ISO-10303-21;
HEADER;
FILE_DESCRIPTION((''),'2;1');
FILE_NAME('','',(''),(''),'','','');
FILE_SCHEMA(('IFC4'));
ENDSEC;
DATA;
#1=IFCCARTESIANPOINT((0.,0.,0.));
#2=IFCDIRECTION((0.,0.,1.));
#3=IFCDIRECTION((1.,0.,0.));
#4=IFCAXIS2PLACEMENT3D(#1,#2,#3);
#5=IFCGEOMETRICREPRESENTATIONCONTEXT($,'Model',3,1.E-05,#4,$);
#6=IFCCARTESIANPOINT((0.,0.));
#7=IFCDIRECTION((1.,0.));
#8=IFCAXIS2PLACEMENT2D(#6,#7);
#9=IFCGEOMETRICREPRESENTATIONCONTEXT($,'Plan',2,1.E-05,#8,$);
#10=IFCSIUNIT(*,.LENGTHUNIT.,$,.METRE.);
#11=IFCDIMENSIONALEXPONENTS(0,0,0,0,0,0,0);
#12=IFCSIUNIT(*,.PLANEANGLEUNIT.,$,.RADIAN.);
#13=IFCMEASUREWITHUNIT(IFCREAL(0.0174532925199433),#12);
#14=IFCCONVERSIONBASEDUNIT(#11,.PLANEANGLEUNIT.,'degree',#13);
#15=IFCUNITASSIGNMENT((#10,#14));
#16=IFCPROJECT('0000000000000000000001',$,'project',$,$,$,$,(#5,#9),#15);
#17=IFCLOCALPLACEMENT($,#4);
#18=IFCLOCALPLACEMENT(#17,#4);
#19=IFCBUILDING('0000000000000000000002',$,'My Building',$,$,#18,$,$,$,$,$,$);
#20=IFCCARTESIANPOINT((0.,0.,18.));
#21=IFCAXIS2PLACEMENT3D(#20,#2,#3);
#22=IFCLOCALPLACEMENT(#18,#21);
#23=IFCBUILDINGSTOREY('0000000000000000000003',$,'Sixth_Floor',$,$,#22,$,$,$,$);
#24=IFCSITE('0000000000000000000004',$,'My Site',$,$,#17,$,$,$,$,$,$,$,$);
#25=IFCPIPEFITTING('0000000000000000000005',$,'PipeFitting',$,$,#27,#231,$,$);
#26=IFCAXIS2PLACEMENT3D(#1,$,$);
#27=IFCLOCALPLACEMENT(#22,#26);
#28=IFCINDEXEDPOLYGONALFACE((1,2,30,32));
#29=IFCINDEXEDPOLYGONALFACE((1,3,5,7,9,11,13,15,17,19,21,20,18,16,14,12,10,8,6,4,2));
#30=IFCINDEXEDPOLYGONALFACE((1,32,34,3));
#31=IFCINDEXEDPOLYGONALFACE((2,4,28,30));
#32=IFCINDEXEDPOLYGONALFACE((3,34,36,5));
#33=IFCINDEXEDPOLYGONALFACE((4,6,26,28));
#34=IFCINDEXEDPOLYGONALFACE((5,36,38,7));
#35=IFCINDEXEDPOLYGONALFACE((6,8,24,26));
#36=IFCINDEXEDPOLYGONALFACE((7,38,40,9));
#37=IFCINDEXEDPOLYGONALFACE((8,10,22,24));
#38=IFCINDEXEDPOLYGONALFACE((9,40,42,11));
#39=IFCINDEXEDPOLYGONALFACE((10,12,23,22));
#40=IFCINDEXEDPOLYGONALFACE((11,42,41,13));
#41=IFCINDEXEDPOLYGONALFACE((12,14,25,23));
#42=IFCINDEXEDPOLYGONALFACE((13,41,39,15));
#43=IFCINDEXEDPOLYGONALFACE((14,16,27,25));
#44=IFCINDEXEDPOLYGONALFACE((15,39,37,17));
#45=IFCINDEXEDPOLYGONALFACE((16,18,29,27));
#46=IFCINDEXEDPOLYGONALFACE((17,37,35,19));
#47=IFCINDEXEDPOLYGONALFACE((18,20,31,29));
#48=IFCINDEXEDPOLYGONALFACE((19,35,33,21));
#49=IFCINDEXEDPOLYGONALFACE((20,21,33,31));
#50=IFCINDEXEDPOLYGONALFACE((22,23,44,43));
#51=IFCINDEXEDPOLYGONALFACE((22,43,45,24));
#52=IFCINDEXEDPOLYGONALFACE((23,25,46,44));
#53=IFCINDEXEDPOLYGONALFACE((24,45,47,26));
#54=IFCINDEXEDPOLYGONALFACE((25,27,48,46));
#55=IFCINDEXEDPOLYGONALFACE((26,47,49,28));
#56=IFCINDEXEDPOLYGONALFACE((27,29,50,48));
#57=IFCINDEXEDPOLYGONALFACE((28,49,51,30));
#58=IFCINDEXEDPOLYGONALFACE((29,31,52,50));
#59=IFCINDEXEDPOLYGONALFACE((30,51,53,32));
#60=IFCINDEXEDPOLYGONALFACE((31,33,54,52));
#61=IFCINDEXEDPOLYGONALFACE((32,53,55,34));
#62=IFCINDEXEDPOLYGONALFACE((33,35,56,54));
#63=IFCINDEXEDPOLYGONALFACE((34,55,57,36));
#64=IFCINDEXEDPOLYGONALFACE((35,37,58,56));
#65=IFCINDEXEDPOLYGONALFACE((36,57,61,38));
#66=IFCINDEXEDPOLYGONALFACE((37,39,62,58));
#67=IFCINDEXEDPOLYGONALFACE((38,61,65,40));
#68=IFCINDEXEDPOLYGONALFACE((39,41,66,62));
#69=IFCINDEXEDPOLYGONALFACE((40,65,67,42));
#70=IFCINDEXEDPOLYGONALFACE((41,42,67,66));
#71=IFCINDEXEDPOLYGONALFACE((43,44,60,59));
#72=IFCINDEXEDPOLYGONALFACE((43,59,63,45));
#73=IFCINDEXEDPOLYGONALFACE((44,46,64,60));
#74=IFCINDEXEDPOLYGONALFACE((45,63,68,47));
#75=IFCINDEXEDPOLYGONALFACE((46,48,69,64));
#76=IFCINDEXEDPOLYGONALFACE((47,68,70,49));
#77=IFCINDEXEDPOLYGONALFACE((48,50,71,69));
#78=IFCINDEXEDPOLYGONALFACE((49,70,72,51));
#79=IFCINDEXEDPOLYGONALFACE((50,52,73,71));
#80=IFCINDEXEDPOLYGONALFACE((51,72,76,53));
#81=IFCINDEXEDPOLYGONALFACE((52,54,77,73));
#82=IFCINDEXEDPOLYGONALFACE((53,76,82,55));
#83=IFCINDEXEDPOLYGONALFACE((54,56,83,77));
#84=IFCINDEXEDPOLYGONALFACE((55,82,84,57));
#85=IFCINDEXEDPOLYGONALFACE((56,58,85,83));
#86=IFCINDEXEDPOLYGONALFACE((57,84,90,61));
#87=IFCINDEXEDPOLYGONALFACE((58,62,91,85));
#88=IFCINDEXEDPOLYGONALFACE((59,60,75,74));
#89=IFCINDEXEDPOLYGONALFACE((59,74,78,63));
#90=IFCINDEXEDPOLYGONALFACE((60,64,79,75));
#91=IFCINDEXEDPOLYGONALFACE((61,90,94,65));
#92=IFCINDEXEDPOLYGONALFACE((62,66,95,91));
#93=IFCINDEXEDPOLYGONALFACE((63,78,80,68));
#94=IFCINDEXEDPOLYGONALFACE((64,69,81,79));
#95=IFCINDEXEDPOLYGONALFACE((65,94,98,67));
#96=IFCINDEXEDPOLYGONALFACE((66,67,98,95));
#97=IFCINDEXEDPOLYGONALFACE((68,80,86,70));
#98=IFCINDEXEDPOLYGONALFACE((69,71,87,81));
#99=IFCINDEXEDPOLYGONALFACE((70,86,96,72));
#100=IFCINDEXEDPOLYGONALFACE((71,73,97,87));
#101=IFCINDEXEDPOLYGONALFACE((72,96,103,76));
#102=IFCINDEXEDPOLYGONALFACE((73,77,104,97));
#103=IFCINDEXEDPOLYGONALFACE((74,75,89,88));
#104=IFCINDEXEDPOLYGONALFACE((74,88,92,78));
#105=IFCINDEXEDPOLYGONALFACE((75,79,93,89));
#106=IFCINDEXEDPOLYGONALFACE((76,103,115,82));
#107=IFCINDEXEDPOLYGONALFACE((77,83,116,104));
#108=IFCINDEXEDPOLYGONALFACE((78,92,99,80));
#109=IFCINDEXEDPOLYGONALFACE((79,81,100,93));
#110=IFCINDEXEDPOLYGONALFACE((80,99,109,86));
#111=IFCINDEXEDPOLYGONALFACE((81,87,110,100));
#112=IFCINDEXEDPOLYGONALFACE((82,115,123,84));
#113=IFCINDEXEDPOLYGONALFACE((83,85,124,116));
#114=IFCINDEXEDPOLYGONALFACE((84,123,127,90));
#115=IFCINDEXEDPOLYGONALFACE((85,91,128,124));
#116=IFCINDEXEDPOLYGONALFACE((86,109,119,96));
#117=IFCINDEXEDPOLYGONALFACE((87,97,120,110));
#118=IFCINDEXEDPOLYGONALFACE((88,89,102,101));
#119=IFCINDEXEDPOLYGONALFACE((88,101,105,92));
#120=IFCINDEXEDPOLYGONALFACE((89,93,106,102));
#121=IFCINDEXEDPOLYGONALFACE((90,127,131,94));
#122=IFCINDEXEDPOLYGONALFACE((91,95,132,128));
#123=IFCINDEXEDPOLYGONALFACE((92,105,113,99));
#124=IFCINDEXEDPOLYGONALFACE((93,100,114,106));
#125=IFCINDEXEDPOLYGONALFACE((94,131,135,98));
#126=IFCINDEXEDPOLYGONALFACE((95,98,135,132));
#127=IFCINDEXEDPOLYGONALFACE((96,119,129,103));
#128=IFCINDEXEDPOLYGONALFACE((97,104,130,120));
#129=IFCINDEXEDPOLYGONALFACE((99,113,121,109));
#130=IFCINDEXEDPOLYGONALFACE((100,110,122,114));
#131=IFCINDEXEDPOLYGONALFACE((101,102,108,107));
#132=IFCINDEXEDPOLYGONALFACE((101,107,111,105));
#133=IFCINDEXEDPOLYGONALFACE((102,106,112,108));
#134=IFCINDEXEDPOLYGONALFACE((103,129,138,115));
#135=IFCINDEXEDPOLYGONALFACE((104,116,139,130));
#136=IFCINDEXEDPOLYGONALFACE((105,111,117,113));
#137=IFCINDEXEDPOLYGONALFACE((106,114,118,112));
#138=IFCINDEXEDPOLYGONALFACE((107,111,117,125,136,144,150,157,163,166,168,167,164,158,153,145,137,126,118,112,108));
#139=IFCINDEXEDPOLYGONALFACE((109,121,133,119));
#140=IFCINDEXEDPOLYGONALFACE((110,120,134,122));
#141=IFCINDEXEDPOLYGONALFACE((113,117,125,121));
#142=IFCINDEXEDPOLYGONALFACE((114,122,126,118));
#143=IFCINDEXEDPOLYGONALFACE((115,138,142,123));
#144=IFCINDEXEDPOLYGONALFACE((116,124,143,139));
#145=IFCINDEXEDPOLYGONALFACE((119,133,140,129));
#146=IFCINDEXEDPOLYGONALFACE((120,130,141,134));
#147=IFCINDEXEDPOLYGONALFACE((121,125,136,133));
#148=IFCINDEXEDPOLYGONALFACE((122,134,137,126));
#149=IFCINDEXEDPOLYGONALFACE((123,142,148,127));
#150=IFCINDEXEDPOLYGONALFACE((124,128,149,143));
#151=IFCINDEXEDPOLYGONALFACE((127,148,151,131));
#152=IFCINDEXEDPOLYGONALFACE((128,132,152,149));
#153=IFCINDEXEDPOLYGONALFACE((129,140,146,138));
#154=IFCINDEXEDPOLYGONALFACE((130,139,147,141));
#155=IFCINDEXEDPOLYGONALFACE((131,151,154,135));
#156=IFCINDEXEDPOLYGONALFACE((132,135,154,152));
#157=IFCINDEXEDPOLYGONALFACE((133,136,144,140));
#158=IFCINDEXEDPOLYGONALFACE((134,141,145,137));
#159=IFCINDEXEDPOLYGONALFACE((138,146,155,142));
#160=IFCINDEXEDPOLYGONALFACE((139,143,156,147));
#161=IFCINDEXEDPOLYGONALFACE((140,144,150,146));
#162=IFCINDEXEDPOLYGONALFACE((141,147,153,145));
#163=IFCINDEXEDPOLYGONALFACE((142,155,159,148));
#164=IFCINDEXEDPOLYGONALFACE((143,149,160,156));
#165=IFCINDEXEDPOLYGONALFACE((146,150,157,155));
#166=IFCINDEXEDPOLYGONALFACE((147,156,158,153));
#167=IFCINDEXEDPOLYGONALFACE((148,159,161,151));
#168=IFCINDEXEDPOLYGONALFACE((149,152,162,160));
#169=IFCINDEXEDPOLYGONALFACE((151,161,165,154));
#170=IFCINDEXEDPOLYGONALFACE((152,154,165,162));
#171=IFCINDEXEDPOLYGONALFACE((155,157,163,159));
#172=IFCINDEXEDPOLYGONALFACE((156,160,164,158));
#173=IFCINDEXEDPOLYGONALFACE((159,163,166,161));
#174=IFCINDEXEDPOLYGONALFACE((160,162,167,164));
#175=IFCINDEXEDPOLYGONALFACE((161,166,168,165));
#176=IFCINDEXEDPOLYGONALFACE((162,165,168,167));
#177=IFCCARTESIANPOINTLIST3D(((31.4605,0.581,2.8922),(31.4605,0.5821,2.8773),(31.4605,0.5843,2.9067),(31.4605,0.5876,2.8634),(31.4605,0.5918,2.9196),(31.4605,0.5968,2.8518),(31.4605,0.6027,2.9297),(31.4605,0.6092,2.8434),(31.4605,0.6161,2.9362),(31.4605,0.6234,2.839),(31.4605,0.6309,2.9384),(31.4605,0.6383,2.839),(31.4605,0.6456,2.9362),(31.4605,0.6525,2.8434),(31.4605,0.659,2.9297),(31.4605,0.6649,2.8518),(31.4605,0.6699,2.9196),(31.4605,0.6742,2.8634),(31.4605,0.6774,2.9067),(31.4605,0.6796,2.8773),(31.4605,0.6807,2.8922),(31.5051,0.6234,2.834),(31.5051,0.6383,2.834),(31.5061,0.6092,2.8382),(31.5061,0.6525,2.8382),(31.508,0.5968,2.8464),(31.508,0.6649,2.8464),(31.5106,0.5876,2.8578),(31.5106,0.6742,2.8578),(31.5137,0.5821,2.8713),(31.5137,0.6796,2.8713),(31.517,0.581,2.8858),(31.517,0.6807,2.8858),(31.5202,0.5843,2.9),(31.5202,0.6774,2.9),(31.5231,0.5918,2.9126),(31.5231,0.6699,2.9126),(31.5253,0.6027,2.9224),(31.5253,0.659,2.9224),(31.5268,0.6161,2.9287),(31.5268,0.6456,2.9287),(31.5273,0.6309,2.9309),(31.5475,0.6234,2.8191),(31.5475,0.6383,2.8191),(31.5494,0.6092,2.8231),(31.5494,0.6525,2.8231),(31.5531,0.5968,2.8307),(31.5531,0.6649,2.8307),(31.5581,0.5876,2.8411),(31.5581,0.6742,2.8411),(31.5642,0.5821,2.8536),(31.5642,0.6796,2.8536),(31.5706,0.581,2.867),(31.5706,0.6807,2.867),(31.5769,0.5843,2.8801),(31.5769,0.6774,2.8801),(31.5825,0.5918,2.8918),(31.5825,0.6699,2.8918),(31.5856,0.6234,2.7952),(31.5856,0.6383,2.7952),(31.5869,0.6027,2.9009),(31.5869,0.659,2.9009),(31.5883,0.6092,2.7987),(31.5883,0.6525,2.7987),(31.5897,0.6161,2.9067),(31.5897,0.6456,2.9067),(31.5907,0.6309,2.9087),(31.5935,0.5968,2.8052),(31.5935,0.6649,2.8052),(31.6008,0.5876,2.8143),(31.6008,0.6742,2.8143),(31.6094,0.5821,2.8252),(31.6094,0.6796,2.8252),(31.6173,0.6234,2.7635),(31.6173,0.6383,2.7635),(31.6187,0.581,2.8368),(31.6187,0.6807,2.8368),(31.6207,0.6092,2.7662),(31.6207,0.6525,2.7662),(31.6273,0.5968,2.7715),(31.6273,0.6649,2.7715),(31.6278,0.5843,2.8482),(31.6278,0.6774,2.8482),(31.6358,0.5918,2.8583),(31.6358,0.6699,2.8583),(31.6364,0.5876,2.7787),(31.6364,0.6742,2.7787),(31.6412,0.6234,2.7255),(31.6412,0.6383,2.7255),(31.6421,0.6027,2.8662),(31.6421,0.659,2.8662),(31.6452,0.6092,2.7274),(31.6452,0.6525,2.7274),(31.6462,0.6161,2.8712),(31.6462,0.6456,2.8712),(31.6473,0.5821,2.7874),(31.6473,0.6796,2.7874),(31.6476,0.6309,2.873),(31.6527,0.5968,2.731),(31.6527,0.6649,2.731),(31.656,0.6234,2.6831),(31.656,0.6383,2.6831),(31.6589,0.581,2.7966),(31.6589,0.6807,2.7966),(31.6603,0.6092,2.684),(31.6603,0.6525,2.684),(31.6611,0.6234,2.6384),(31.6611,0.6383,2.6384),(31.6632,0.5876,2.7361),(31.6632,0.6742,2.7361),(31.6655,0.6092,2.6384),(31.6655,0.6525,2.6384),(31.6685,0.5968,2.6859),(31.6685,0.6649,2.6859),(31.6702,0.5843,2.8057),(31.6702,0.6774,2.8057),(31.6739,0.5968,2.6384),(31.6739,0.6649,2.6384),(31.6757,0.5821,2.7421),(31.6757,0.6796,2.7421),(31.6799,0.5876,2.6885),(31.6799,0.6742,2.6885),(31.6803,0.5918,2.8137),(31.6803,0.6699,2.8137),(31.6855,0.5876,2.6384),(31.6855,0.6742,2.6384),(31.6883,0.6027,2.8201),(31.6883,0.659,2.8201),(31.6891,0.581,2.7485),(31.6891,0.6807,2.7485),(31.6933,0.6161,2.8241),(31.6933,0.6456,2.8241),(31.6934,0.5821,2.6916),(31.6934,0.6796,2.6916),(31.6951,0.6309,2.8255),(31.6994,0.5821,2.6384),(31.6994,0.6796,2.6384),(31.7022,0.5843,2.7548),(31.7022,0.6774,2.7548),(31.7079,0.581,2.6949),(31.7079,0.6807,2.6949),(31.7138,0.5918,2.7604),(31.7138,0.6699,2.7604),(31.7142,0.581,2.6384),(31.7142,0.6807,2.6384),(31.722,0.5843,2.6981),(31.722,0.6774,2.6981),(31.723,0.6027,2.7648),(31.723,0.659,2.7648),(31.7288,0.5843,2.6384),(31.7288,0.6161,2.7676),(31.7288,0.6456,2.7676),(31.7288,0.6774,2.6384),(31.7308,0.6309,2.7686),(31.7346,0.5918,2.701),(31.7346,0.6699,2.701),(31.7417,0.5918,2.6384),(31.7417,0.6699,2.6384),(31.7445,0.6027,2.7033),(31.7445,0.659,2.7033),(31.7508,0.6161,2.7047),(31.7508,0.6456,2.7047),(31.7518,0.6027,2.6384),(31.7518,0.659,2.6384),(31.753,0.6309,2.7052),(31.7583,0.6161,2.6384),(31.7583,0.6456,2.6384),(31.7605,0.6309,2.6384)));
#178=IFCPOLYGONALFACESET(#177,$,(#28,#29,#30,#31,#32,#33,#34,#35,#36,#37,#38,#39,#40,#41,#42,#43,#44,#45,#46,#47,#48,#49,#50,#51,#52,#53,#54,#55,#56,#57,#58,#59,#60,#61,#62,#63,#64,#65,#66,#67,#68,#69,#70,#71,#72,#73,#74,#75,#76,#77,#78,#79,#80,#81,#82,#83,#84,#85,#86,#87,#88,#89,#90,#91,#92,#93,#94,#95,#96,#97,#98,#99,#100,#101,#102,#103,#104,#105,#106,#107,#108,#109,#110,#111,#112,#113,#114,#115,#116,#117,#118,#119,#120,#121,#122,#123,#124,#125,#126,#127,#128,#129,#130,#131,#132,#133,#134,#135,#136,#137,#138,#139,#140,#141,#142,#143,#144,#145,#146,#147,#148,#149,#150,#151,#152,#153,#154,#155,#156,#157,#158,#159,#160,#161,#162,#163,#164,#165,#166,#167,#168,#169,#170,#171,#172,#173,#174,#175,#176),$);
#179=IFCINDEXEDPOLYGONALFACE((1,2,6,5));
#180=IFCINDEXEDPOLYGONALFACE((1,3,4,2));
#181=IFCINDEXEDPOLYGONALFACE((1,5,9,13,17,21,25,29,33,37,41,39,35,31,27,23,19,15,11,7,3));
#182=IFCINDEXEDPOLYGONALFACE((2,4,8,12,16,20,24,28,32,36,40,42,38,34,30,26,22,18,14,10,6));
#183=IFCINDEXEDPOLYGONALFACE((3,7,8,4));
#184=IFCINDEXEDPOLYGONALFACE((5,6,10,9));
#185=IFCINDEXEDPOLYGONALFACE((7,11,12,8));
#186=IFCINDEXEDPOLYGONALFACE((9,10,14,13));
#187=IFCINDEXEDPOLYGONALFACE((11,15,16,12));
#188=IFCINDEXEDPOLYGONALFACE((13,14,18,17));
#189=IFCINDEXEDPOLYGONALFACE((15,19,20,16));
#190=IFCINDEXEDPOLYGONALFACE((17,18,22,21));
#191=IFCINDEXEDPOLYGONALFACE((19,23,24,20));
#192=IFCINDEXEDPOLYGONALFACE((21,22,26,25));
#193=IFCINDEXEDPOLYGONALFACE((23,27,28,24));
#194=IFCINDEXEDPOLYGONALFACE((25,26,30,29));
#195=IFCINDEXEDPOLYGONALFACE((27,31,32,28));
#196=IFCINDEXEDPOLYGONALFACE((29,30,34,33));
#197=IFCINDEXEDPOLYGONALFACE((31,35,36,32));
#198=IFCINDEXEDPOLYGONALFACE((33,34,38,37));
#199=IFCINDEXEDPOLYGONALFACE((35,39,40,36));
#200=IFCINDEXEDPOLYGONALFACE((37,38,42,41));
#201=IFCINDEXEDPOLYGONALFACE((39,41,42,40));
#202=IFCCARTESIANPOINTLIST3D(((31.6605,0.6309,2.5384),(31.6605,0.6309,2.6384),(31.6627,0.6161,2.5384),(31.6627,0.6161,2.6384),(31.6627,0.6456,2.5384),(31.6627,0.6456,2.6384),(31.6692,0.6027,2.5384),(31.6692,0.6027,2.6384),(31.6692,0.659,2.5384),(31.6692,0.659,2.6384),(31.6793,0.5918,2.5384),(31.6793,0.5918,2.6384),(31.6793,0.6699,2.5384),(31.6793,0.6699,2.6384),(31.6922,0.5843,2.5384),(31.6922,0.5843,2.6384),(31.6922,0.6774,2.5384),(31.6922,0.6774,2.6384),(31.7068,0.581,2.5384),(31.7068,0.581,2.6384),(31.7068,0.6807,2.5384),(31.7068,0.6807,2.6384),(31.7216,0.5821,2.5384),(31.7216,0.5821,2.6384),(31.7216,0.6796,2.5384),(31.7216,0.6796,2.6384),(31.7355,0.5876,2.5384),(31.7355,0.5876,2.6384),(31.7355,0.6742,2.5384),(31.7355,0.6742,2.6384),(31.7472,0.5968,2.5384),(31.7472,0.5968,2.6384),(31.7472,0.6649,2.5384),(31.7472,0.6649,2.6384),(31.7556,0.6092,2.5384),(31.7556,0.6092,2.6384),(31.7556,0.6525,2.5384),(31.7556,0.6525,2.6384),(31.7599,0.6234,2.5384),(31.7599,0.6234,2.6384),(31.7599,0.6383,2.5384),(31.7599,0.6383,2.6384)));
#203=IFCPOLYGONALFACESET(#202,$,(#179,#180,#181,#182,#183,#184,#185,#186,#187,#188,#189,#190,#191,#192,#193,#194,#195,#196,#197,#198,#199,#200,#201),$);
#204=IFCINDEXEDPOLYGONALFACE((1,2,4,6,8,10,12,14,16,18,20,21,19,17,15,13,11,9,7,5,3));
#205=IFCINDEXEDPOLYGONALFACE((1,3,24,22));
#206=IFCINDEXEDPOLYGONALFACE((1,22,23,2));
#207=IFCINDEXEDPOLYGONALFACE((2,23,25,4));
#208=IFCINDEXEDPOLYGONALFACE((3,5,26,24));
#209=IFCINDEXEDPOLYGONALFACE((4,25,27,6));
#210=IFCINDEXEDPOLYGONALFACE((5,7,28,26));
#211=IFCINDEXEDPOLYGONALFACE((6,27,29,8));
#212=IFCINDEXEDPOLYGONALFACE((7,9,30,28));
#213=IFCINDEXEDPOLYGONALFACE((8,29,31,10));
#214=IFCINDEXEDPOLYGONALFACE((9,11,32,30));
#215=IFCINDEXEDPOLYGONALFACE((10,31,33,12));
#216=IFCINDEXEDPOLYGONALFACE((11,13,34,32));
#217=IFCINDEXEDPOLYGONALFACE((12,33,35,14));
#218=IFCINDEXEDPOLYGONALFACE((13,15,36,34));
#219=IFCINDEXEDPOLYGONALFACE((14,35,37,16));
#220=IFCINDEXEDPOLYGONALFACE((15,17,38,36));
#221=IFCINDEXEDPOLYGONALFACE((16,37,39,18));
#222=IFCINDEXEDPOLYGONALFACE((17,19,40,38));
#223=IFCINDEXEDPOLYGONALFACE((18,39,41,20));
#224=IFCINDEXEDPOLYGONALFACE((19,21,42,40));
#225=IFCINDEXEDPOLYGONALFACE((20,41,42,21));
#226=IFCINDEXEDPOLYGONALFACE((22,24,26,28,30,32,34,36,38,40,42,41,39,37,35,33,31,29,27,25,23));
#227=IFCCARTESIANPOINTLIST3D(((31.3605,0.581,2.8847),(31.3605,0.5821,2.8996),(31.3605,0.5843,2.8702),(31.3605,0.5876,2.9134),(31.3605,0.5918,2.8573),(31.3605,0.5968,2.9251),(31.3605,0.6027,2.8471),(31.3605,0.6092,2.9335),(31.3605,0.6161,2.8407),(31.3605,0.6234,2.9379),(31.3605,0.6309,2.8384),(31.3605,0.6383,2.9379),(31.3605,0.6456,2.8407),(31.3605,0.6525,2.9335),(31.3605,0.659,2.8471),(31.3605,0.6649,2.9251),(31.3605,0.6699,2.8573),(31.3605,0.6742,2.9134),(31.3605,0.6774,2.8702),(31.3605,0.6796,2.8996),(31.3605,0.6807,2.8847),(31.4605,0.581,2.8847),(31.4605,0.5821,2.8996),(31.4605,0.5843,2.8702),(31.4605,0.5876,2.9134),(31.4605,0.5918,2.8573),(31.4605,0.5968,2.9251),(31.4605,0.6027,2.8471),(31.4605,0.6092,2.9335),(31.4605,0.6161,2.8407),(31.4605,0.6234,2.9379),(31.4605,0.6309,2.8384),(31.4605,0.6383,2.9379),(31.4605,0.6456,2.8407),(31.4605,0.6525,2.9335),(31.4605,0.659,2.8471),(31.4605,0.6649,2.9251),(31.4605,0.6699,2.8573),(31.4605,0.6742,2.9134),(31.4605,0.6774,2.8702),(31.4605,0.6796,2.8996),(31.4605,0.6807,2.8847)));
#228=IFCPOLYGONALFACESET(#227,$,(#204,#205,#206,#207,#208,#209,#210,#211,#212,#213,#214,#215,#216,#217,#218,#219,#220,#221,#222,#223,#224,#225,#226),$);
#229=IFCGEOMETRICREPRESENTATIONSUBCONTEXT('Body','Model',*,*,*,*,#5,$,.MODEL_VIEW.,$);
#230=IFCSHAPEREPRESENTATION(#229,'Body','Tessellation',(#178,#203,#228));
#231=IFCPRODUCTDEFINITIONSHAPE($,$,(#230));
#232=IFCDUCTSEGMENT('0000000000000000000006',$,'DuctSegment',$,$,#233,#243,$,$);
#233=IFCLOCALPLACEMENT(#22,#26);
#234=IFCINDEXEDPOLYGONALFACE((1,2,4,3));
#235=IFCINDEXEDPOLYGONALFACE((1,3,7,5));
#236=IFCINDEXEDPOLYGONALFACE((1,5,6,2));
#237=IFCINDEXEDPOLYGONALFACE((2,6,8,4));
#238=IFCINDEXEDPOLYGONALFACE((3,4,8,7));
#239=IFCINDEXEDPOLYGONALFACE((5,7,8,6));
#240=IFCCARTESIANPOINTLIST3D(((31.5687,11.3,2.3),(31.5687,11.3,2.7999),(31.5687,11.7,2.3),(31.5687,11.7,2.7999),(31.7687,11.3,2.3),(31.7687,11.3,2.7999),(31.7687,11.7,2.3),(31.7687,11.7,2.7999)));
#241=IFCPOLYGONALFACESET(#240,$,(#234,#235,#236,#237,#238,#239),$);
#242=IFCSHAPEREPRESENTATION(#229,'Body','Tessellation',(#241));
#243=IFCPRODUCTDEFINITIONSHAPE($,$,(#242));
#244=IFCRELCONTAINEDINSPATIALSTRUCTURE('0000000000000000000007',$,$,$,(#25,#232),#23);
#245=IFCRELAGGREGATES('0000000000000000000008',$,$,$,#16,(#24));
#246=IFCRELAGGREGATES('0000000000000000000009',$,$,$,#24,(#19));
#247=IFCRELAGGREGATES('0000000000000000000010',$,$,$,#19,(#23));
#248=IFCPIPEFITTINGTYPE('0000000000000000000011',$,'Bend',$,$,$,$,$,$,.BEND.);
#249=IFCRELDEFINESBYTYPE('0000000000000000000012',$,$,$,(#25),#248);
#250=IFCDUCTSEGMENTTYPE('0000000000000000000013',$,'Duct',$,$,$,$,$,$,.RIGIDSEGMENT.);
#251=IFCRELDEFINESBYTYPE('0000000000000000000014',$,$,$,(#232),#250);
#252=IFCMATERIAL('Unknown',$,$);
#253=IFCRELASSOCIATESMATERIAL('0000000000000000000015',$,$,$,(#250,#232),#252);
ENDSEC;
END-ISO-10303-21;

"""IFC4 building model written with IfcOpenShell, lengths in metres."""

from ifc_helpers import new_model, entity, si_unit, converted_unit, frame, origin_with_axes, origin_2d_with_axis, place, context, subcontext, project, spatial, rectangle, circle, extrude, source, transform, mapped, material, material_profile, profile_set, profile_usage, type_object, type_shapes, element, save


model = new_model("IFC4")

# Units and contexts
model_context = context("Model", 3, precision=1e-05, world=origin_with_axes())
plan_context = context("Plan", 2, precision=1e-05, world=origin_2d_with_axis())
body_context = subcontext(model_context, "Body", "Model", "MODEL_VIEW")
ifc_project = project(units=[si_unit("LENGTHUNIT", "METRE"), converted_unit("PLANEANGLEUNIT", "degree", entity("IfcReal", 0.0174532925199433), si_unit("PLANEANGLEUNIT", "RADIAN"), dimensions=[0, 0, 0, 0, 0, 0, 0])], contexts=[model_context, plan_context])

# Site, building, storey
site_placement = place(None, origin_with_axes())
site = spatial("IfcSite", under=ifc_project, at=site_placement, Name="My Site")
building_placement = place(site_placement, origin_with_axes())
building = spatial("IfcBuilding", under=site, at=building_placement, Name="My Building")
storey_placement = place(building_placement, frame((0.0, 0.0, 18.0), z_axis=(0.0, 0.0, 1.0), x_axis=(1.0, 0.0, 0.0)))
storey = spatial("IfcBuildingStorey", under=building, at=storey_placement, Name="Sixth_Floor")

# Shared definitions
ifc_material = material(Name="Unknown")

# Pipe fitting
pipe_fitting_type = type_object("IfcPipeFittingType", Name="Bend", PredefinedType="BEND")
shared_shape = source(origin_with_axes(), body_context, "Body", "SolidModel", [
    entity("IfcSweptDiskSolid", entity("IfcIndexedPolyCurve", entity("IfcCartesianPointList3D", [[0.0, 0.0, -0.1], [0.0732, 0.0, -0.2768], [0.25, 0.0, -0.35]]), [entity("IfcArcIndex", [1, 2, 3])]), 0.05),
    extrude(circle(Radius=0.05), origin_with_axes(), (0.0, 0.0, -1.0), 0.1),
    extrude(circle(Radius=0.05), frame((0.25, 0.0, -0.35), z_axis=(1.0, 0.0, 0.0), x_axis=(0.0, 0.0, 1.0)), (0.0, 0.0, 1.0), 0.1),
])
type_shapes(pipe_fitting_type, [shared_shape])
for number, where, z_axis, x_axis, name in (
    (1, (31.7105, 0.6309, 2.5384), (0.000001, 0.0, -1.0), (-1.0, -0.000001, -0.000001), "PipeFitting"),
):
    element("IfcPipeFitting", number, at=place(storey_placement, frame(where, z_axis=z_axis, x_axis=x_axis)), inside=storey, type_object=pipe_fitting_type, Name=name, context=body_context, shape_type="MappedRepresentation", body=[
        mapped(shared_shape, transform((0.0, 0.0, 0.0), x_axis=(1.0, 0.0, 0.0), y_axis=(0.0, 1.0, 0.0), z_axis=(0.0, 0.0, 1.0), scale=1.0)),
    ])

# Duct segment
ifc_material_profile_1 = material_profile(ifc_material, rectangle(XDim=0.4, YDim=0.2))
ifc_profile_set_1 = profile_set([ifc_material_profile_1])
ifc_profile_usage_1 = profile_usage(ifc_profile_set_1, cardinal=5)
duct_segment_type = type_object("IfcDuctSegmentType", Name="Duct", PredefinedType="RIGIDSEGMENT", material=ifc_profile_set_1)
duct_segment_placement = place(storey_placement, frame((31.6687, 11.5, 2.7999), z_axis=(0.0, 0.0, -1.0), x_axis=(0.0, 1.0, 0.0)))
element("IfcDuctSegment", 2, at=duct_segment_placement, inside=storey, type_object=duct_segment_type, material=ifc_profile_usage_1, Name="DuctSegment", context=body_context, shape_type="SweptSolid", body=[
    extrude(rectangle(XDim=0.4, YDim=0.2), origin_with_axes(), (0.0, 0.0, 1.0), 0.5),
])

save(model, "model.ifc")
